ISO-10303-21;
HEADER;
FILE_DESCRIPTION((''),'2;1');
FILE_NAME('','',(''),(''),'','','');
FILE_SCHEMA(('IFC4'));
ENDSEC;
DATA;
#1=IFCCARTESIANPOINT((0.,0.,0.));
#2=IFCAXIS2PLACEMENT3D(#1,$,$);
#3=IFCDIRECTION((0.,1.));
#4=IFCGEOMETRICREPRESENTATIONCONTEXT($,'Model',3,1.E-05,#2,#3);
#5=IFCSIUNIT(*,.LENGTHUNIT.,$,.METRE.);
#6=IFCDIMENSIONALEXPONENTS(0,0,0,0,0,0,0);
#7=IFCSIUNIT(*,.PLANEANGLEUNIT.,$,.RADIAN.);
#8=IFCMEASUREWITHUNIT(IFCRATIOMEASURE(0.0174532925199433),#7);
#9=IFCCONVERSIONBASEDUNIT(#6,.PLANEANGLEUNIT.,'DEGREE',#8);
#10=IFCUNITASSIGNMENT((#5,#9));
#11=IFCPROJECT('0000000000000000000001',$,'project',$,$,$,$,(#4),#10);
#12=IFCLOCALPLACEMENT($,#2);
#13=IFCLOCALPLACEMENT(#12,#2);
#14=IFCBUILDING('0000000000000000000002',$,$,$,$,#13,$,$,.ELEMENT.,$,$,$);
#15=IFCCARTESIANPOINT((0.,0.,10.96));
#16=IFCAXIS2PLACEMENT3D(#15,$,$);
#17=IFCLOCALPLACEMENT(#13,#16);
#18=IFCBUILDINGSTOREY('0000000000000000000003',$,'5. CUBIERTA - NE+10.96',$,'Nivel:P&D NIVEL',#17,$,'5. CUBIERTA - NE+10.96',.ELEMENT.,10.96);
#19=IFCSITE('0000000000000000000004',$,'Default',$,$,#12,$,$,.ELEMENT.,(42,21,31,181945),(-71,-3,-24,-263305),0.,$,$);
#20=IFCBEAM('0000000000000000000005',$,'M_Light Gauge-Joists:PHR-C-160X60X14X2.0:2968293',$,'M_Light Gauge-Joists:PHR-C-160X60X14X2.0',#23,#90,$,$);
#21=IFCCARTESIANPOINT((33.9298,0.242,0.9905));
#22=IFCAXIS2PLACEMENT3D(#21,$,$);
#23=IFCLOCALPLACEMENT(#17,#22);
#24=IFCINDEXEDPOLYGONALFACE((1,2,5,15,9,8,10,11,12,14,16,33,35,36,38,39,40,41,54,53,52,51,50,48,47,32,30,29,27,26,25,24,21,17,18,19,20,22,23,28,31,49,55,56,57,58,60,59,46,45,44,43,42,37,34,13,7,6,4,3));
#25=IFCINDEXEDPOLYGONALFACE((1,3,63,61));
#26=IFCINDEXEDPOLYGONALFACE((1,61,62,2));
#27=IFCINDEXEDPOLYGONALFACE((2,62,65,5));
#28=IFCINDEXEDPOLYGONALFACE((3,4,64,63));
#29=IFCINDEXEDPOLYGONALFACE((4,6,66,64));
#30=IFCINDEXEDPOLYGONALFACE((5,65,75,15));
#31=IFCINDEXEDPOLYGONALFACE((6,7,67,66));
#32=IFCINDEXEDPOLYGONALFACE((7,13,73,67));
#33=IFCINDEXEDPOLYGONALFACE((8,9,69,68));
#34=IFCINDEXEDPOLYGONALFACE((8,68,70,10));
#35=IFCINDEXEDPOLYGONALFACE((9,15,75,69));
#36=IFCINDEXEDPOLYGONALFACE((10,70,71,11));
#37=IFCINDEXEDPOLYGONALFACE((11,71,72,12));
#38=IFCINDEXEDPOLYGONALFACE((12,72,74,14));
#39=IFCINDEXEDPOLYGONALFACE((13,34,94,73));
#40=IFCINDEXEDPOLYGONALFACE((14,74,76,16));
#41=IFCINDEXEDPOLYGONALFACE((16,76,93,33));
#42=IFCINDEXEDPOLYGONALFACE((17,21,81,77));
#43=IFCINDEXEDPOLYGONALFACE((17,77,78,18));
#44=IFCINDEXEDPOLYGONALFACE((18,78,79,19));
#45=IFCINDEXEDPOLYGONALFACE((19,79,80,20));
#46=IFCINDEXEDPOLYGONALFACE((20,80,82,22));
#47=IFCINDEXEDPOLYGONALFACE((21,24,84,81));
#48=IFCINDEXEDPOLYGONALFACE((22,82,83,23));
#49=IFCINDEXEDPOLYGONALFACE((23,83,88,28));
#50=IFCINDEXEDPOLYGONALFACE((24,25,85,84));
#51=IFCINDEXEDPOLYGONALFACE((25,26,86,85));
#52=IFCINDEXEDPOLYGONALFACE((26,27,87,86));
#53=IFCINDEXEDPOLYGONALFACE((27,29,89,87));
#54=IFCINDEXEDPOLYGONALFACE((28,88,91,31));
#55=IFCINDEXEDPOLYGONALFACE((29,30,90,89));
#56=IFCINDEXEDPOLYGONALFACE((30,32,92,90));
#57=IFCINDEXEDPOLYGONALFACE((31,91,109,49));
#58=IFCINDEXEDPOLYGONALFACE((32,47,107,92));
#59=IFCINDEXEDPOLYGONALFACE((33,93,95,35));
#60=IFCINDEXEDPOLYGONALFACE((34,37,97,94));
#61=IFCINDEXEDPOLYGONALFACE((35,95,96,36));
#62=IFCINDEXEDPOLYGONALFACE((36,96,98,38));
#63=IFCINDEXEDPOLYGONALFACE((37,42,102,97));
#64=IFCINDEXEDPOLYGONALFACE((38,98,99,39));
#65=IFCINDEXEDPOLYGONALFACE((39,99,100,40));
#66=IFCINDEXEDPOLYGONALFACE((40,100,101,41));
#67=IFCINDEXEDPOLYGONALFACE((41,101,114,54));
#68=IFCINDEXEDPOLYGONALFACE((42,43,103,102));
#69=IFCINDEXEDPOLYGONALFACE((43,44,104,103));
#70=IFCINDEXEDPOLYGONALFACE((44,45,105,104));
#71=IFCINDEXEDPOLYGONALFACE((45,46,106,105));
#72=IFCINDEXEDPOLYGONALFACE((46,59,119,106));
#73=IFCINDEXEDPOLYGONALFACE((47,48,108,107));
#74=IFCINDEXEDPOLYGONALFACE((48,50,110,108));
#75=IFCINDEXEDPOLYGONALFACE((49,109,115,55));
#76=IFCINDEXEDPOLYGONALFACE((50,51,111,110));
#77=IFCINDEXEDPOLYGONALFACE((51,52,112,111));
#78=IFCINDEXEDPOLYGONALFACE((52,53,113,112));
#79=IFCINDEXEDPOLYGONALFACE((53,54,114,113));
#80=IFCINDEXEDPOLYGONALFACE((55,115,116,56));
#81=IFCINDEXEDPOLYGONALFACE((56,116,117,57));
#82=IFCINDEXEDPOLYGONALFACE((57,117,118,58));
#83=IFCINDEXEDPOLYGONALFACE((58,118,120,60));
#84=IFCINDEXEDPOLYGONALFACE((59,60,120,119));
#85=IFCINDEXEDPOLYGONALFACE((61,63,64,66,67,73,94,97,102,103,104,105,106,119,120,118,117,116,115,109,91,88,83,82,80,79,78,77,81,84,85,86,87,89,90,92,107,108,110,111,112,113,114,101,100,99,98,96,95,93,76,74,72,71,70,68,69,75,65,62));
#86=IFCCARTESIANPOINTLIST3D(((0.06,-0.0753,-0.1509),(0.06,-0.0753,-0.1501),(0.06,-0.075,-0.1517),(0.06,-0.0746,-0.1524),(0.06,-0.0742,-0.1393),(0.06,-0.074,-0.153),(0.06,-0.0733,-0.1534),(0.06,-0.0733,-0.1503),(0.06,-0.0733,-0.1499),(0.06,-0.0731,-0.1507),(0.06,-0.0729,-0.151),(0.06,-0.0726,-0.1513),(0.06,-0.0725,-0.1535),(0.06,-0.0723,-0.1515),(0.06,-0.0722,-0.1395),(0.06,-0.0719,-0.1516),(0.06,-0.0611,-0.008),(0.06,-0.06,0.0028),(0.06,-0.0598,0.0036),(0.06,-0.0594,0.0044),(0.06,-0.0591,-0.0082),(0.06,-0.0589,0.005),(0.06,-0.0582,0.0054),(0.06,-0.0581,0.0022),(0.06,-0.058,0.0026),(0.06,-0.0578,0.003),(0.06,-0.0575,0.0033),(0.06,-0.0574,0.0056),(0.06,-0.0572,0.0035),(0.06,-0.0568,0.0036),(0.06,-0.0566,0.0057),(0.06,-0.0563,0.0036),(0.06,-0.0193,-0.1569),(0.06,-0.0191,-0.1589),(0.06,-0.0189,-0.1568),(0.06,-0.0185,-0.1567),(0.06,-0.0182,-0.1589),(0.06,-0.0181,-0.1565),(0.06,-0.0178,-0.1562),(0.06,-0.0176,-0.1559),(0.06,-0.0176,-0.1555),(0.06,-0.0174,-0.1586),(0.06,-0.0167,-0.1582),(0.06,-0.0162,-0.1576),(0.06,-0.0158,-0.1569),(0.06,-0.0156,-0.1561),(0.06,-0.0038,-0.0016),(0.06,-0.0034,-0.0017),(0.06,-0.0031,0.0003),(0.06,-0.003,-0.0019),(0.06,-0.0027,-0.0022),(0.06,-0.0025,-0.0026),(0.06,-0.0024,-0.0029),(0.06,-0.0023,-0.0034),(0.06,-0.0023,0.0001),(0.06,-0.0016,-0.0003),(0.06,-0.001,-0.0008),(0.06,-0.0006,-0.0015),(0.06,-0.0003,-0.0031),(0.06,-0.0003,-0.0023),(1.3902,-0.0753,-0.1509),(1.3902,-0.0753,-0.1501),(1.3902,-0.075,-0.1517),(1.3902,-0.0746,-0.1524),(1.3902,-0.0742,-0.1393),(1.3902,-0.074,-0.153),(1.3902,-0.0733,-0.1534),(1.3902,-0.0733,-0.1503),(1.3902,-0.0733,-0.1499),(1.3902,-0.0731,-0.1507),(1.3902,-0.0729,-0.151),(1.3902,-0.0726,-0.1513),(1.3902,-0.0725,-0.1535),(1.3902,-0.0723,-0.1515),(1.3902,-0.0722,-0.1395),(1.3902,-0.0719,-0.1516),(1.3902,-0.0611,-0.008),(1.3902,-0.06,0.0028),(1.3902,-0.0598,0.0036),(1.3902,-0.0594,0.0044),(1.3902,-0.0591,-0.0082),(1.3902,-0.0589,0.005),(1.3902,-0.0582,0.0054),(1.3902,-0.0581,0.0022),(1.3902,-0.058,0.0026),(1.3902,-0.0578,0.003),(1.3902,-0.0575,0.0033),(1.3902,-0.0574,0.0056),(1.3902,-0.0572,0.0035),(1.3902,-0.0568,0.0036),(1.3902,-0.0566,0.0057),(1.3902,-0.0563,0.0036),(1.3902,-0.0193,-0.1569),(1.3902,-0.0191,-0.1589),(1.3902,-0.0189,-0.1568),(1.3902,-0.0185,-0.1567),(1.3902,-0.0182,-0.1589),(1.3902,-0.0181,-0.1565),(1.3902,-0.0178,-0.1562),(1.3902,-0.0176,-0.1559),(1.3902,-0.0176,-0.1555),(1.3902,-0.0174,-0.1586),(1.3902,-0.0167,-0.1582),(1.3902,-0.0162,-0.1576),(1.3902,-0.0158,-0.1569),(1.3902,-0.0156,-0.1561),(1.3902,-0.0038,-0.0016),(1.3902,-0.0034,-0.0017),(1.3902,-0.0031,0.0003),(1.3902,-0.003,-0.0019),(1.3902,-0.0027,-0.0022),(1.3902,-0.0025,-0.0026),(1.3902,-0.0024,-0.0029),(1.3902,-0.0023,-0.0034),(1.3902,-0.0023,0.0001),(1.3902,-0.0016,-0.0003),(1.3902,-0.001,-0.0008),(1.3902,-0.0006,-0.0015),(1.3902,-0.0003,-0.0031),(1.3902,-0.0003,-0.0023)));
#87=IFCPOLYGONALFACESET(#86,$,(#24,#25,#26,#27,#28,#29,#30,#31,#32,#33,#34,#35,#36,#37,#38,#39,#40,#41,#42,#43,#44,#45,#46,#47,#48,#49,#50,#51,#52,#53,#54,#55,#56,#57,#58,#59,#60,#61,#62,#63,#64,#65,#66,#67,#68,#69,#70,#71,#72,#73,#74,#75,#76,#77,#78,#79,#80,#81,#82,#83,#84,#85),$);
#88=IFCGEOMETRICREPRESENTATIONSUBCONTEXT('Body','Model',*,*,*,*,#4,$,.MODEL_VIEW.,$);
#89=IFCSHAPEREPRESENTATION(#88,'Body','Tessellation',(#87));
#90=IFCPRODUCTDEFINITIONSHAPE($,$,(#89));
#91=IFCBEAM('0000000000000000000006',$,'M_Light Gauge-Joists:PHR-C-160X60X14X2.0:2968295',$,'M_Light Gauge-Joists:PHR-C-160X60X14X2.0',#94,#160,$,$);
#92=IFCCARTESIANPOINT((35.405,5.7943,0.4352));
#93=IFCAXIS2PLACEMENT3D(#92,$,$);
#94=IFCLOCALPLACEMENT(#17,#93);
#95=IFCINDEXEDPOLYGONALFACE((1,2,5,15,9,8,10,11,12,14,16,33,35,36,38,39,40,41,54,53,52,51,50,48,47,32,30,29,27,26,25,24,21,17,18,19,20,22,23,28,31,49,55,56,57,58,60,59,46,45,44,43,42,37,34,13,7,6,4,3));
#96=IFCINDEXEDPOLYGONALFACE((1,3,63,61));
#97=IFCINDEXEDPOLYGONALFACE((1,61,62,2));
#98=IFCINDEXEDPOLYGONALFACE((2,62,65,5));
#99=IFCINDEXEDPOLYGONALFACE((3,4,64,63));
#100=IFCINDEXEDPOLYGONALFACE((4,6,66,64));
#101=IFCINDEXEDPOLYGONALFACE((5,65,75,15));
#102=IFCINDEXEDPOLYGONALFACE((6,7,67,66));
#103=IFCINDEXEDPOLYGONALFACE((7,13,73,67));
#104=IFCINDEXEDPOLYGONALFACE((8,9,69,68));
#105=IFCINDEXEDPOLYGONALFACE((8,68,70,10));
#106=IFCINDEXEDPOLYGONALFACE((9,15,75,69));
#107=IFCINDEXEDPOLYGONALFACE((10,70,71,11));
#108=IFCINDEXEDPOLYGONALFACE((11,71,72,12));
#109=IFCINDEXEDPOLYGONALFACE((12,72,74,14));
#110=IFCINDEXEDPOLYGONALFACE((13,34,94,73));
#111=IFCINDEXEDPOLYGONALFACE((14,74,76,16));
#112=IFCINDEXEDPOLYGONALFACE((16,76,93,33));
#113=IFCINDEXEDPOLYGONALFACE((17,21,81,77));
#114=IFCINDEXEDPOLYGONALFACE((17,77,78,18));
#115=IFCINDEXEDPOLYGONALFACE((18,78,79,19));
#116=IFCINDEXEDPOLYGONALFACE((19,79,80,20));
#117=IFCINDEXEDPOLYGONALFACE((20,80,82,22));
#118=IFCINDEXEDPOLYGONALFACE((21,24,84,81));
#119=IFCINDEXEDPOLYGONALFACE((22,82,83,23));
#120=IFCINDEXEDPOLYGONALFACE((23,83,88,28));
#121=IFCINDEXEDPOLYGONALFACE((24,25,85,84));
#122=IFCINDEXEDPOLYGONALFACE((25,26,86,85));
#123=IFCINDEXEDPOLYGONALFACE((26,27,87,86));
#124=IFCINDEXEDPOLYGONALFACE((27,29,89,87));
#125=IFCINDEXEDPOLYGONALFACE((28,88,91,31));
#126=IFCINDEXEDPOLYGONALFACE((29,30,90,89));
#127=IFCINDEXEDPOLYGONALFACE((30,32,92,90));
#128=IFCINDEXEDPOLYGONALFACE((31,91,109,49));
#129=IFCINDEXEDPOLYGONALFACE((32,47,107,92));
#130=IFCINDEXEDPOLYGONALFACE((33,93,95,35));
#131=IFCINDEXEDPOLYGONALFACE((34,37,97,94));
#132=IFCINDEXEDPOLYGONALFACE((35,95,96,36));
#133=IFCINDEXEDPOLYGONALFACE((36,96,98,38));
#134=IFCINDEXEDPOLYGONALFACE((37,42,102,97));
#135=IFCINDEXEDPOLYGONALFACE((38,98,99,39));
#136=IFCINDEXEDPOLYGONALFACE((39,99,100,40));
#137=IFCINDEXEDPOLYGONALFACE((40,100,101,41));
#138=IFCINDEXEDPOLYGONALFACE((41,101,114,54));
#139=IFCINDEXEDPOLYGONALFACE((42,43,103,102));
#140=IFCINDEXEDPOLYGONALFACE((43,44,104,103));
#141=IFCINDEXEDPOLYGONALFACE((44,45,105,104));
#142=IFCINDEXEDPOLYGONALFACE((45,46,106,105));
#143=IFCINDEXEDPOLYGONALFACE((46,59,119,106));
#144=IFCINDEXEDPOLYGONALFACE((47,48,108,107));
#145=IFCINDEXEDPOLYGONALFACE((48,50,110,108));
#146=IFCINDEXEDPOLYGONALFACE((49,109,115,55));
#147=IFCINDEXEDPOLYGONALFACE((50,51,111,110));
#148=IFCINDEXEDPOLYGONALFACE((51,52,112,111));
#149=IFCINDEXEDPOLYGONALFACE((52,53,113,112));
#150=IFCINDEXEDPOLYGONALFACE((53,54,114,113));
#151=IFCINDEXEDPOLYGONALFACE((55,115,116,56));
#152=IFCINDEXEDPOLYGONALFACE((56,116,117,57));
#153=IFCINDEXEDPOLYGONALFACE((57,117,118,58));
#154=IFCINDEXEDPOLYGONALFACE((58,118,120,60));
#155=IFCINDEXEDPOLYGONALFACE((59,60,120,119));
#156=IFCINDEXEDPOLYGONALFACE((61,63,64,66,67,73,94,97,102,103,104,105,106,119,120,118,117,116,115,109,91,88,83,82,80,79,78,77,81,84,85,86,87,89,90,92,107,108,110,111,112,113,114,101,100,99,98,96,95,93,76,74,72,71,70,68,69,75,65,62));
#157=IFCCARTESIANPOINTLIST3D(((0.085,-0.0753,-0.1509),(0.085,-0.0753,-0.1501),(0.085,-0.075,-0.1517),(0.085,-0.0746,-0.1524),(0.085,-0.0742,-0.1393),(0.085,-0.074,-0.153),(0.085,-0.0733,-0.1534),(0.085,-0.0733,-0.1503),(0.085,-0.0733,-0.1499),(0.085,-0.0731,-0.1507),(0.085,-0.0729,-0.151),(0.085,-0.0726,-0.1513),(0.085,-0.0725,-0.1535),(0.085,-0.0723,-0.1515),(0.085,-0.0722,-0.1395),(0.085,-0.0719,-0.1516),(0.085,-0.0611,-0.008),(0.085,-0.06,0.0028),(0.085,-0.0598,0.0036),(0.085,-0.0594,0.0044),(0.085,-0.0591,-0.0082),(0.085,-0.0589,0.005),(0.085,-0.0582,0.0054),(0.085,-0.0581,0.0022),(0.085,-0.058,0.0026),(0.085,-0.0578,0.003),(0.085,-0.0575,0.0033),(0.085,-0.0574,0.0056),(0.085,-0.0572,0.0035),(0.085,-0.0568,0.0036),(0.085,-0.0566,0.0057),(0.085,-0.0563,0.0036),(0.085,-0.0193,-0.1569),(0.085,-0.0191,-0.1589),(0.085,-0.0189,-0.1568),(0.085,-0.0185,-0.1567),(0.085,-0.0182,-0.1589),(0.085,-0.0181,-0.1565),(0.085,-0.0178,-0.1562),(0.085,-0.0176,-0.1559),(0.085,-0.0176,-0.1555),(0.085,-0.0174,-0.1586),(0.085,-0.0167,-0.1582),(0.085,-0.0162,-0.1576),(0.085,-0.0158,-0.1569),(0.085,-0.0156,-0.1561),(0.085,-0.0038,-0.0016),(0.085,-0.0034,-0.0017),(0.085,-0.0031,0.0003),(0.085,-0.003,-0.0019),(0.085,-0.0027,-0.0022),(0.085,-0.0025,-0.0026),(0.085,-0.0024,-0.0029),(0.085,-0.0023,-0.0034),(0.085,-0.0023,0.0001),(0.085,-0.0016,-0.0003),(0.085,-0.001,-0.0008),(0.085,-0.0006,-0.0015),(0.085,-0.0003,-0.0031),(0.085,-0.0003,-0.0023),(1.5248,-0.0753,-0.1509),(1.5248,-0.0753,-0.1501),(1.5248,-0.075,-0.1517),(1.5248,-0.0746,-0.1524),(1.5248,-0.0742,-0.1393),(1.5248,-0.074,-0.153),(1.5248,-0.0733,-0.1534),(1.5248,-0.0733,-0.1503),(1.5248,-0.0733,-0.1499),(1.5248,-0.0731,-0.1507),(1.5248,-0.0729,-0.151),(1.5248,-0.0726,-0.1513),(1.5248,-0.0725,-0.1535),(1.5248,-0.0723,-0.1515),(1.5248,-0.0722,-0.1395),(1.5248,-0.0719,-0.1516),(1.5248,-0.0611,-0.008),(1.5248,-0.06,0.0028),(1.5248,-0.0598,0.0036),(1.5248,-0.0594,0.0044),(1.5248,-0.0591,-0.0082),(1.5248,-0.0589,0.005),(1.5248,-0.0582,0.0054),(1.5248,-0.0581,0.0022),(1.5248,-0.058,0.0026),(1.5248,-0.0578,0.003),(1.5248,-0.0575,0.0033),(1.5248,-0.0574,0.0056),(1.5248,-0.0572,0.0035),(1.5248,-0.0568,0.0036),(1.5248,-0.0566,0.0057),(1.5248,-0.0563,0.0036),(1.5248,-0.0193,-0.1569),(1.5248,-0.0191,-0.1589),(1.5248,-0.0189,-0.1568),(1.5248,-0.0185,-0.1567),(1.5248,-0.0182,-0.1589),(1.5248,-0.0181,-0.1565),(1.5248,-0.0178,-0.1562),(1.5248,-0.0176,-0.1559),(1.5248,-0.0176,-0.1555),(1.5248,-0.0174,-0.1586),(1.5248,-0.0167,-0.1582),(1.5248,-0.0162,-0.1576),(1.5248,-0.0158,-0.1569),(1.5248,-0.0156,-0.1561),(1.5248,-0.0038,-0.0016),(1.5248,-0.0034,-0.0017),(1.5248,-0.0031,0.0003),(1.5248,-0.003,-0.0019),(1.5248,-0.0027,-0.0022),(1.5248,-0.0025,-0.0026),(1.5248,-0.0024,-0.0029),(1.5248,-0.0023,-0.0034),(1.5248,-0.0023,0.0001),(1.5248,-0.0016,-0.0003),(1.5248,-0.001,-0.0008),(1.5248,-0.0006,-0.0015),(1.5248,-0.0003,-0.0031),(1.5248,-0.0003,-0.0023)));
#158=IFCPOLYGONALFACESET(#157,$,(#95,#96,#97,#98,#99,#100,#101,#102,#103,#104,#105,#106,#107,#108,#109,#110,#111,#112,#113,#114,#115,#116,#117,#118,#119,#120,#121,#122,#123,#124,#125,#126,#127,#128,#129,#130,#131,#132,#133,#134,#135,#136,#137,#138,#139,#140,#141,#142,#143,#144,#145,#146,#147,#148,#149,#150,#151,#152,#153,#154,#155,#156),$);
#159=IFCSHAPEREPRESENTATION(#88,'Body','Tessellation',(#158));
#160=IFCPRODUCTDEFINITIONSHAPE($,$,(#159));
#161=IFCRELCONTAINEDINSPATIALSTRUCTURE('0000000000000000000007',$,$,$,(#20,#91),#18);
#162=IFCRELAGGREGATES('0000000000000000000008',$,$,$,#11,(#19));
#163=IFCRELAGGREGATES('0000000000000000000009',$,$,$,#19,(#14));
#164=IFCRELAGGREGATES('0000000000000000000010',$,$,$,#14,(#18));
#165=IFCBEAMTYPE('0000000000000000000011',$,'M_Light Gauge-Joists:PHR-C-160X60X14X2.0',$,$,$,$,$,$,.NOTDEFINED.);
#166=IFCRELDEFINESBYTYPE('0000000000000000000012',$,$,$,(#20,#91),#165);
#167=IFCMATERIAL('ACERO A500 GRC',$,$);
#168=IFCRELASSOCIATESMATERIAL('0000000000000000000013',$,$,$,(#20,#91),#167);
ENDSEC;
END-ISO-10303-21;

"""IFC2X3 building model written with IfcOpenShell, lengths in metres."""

from ifc_helpers import new_model, entity, si_unit, converted_unit, direction, frame, frame_2d, origin, place, context, subcontext, project, spatial, polyline, circle_curve, parameter, trimmed, segment, composite_curve, outline, extrude, material, type_object, element, save


model = new_model("IFC2X3")

# Units and contexts
model_context = context("Model", 3, precision=1e-05, world=origin(), true_north=direction((0.0, 1.0)))
body_context = subcontext(model_context, "Body", "Model", "MODEL_VIEW")
ifc_project = project(units=[si_unit("LENGTHUNIT", "METRE"), converted_unit("PLANEANGLEUNIT", "DEGREE", entity("IfcRatioMeasure", 0.0174532925199433), si_unit("PLANEANGLEUNIT", "RADIAN"), dimensions=[0, 0, 0, 0, 0, 0, 0])], contexts=[model_context])

# Site, building, storey
site_placement = place(None, origin())
site = spatial("IfcSite", under=ifc_project, at=site_placement, Name="Default", CompositionType="ELEMENT", RefLatitude=(42, 21, 31, 181945), RefLongitude=(-71, -3, -24, -263305), RefElevation=0.0)
building_placement = place(site_placement, origin())
building = spatial("IfcBuilding", under=site, at=building_placement, CompositionType="ELEMENT")
storey_placement = place(building_placement, frame((0.0, 0.0, 10.96)))
storey = spatial("IfcBuildingStorey", under=building, at=storey_placement, Name="5. CUBIERTA - NE+10.96", ObjectType="Nivel:P&D NIVEL", LongName="5. CUBIERTA - NE+10.96", CompositionType="ELEMENT", Elevation=10.96)

# Beams
ifc_material_1 = material(Name="ACERO A500 GRC")
beam_type_1 = type_object("IfcBeamType", Name="M_Light Gauge-Joists:PHR-C-160X60X14X2.0", PredefinedType="NOTDEFINED")
beam_1_placement = place(storey_placement, frame((33.9298, 0.242, 0.9905)))
element("IfcBeam", 1, at=beam_1_placement, inside=storey, type_object=beam_type_1, material=ifc_material_1, Name="M_Light Gauge-Joists:PHR-C-160X60X14X2.0:2968293", ObjectType="M_Light Gauge-Joists:PHR-C-160X60X14X2.0", context=body_context, shape_type="SweptSolid", body=[
    extrude(outline(composite_curve([segment(polyline([(-0.0768, -0.0358), (0.0768, -0.0358)]), True, "CONTINUOUS"), segment(trimmed(circle_curve(frame_2d((0.0768, -0.0326), x_axis=(0.0, -1.0)), 0.0032), [parameter(0.0)], [parameter(90.0)], True, "PARAMETER"), True, "CONTINUOUS"), segment(polyline([(0.08, -0.0326), (0.08, 0.021)]), True, "CONTINUOUS"), segment(trimmed(circle_curve(frame_2d((0.0768, 0.021), x_axis=(1.0, 0.0)), 0.0032), [parameter(0.0)], [parameter(90.0)], True, "PARAMETER"), True, "CONTINUOUS"), segment(polyline([(0.0768, 0.0242), (0.066, 0.0242)]), True, "CONTINUOUS"), segment(polyline([(0.066, 0.0242), (0.066, 0.0222)]), True, "CONTINUOUS"), segment(polyline([(0.066, 0.0222), (0.0764, 0.0222)]), True, "CONTINUOUS"), segment(trimmed(circle_curve(frame_2d((0.0764, 0.0206), x_axis=(0.0, 1.0)), 0.0016), [parameter(270.0)], [parameter(0.0)], True, "PARAMETER"), False, "CONTINUOUS"), segment(polyline([(0.078, 0.0206), (0.078, -0.0322)]), True, "CONTINUOUS"), segment(trimmed(circle_curve(frame_2d((0.0764, -0.0322), x_axis=(1.0, 0.0)), 0.0016), [parameter(270.0)], [parameter(0.0)], True, "PARAMETER"), False, "CONTINUOUS"), segment(polyline([(0.0764, -0.0338), (-0.0764, -0.0338)]), True, "CONTINUOUS"), segment(trimmed(circle_curve(frame_2d((-0.0764, -0.0322), x_axis=(0.0, -1.0)), 0.0016), [parameter(270.0)], [parameter(0.0)], True, "PARAMETER"), False, "CONTINUOUS"), segment(polyline([(-0.078, -0.0322), (-0.078, 0.0206)]), True, "CONTINUOUS"), segment(trimmed(circle_curve(frame_2d((-0.0764, 0.0206), x_axis=(-1.0, 0.0)), 0.0016), [parameter(270.0)], [parameter(0.0)], True, "PARAMETER"), False, "CONTINUOUS"), segment(polyline([(-0.0764, 0.0222), (-0.066, 0.0222)]), True, "CONTINUOUS"), segment(polyline([(-0.066, 0.0222), (-0.066, 0.0242)]), True, "CONTINUOUS"), segment(polyline([(-0.066, 0.0242), (-0.0768, 0.0242)]), True, "CONTINUOUS"), segment(trimmed(circle_curve(frame_2d((-0.0768, 0.021), x_axis=(0.0, 1.0)), 0.0032), [parameter(0.0)], [parameter(90.0)], True, "PARAMETER"), True, "CONTINUOUS"), segment(polyline([(-0.08, 0.021), (-0.08, -0.0326)]), True, "CONTINUOUS"), segment(trimmed(circle_curve(frame_2d((-0.0768, -0.0326), x_axis=(-1.0, 0.0)), 0.0032), [parameter(0.0)], [parameter(90.0)], True, "PARAMETER"), True, "CONTINUOUS")], self_intersect=False)), frame((0.06, -0.0436, -0.076), z_axis=(1.0, 0.0, 0.0), x_axis=(0.0, 0.099504, 0.995037)), (0.0, 0.0, 1.0), 1.3302),
])
beam_2_placement = place(storey_placement, frame((35.405, 5.7943, 0.4352)))
element("IfcBeam", 2, at=beam_2_placement, inside=storey, type_object=beam_type_1, material=ifc_material_1, Name="M_Light Gauge-Joists:PHR-C-160X60X14X2.0:2968295", ObjectType="M_Light Gauge-Joists:PHR-C-160X60X14X2.0", context=body_context, shape_type="SweptSolid", body=[
    extrude(outline(composite_curve([segment(polyline([(-0.0768, -0.0358), (0.0768, -0.0358)]), True, "CONTINUOUS"), segment(trimmed(circle_curve(frame_2d((0.0768, -0.0326), x_axis=(0.0, -1.0)), 0.0032), [parameter(0.0)], [parameter(90.0)], True, "PARAMETER"), True, "CONTINUOUS"), segment(polyline([(0.08, -0.0326), (0.08, 0.021)]), True, "CONTINUOUS"), segment(trimmed(circle_curve(frame_2d((0.0768, 0.021), x_axis=(1.0, 0.0)), 0.0032), [parameter(0.0)], [parameter(90.0)], True, "PARAMETER"), True, "CONTINUOUS"), segment(polyline([(0.0768, 0.0242), (0.066, 0.0242)]), True, "CONTINUOUS"), segment(polyline([(0.066, 0.0242), (0.066, 0.0222)]), True, "CONTINUOUS"), segment(polyline([(0.066, 0.0222), (0.0764, 0.0222)]), True, "CONTINUOUS"), segment(trimmed(circle_curve(frame_2d((0.0764, 0.0206), x_axis=(0.0, 1.0)), 0.0016), [parameter(270.0)], [parameter(0.0)], True, "PARAMETER"), False, "CONTINUOUS"), segment(polyline([(0.078, 0.0206), (0.078, -0.0322)]), True, "CONTINUOUS"), segment(trimmed(circle_curve(frame_2d((0.0764, -0.0322), x_axis=(1.0, 0.0)), 0.0016), [parameter(270.0)], [parameter(0.0)], True, "PARAMETER"), False, "CONTINUOUS"), segment(polyline([(0.0764, -0.0338), (-0.0764, -0.0338)]), True, "CONTINUOUS"), segment(trimmed(circle_curve(frame_2d((-0.0764, -0.0322), x_axis=(0.0, -1.0)), 0.0016), [parameter(270.0)], [parameter(0.0)], True, "PARAMETER"), False, "CONTINUOUS"), segment(polyline([(-0.078, -0.0322), (-0.078, 0.0206)]), True, "CONTINUOUS"), segment(trimmed(circle_curve(frame_2d((-0.0764, 0.0206), x_axis=(-1.0, 0.0)), 0.0016), [parameter(270.0)], [parameter(0.0)], True, "PARAMETER"), False, "CONTINUOUS"), segment(polyline([(-0.0764, 0.0222), (-0.066, 0.0222)]), True, "CONTINUOUS"), segment(polyline([(-0.066, 0.0222), (-0.066, 0.0242)]), True, "CONTINUOUS"), segment(polyline([(-0.066, 0.0242), (-0.0768, 0.0242)]), True, "CONTINUOUS"), segment(trimmed(circle_curve(frame_2d((-0.0768, 0.021), x_axis=(0.0, 1.0)), 0.0032), [parameter(0.0)], [parameter(90.0)], True, "PARAMETER"), True, "CONTINUOUS"), segment(polyline([(-0.08, 0.021), (-0.08, -0.0326)]), True, "CONTINUOUS"), segment(trimmed(circle_curve(frame_2d((-0.0768, -0.0326), x_axis=(-1.0, 0.0)), 0.0032), [parameter(0.0)], [parameter(90.0)], True, "PARAMETER"), True, "CONTINUOUS")], self_intersect=False)), frame((0.085, -0.0436, -0.076), z_axis=(1.0, 0.0, 0.0), x_axis=(0.0, 0.099504, 0.995037)), (0.0, 0.0, 1.0), 1.4398),
])

save(model, "model.ifc")
